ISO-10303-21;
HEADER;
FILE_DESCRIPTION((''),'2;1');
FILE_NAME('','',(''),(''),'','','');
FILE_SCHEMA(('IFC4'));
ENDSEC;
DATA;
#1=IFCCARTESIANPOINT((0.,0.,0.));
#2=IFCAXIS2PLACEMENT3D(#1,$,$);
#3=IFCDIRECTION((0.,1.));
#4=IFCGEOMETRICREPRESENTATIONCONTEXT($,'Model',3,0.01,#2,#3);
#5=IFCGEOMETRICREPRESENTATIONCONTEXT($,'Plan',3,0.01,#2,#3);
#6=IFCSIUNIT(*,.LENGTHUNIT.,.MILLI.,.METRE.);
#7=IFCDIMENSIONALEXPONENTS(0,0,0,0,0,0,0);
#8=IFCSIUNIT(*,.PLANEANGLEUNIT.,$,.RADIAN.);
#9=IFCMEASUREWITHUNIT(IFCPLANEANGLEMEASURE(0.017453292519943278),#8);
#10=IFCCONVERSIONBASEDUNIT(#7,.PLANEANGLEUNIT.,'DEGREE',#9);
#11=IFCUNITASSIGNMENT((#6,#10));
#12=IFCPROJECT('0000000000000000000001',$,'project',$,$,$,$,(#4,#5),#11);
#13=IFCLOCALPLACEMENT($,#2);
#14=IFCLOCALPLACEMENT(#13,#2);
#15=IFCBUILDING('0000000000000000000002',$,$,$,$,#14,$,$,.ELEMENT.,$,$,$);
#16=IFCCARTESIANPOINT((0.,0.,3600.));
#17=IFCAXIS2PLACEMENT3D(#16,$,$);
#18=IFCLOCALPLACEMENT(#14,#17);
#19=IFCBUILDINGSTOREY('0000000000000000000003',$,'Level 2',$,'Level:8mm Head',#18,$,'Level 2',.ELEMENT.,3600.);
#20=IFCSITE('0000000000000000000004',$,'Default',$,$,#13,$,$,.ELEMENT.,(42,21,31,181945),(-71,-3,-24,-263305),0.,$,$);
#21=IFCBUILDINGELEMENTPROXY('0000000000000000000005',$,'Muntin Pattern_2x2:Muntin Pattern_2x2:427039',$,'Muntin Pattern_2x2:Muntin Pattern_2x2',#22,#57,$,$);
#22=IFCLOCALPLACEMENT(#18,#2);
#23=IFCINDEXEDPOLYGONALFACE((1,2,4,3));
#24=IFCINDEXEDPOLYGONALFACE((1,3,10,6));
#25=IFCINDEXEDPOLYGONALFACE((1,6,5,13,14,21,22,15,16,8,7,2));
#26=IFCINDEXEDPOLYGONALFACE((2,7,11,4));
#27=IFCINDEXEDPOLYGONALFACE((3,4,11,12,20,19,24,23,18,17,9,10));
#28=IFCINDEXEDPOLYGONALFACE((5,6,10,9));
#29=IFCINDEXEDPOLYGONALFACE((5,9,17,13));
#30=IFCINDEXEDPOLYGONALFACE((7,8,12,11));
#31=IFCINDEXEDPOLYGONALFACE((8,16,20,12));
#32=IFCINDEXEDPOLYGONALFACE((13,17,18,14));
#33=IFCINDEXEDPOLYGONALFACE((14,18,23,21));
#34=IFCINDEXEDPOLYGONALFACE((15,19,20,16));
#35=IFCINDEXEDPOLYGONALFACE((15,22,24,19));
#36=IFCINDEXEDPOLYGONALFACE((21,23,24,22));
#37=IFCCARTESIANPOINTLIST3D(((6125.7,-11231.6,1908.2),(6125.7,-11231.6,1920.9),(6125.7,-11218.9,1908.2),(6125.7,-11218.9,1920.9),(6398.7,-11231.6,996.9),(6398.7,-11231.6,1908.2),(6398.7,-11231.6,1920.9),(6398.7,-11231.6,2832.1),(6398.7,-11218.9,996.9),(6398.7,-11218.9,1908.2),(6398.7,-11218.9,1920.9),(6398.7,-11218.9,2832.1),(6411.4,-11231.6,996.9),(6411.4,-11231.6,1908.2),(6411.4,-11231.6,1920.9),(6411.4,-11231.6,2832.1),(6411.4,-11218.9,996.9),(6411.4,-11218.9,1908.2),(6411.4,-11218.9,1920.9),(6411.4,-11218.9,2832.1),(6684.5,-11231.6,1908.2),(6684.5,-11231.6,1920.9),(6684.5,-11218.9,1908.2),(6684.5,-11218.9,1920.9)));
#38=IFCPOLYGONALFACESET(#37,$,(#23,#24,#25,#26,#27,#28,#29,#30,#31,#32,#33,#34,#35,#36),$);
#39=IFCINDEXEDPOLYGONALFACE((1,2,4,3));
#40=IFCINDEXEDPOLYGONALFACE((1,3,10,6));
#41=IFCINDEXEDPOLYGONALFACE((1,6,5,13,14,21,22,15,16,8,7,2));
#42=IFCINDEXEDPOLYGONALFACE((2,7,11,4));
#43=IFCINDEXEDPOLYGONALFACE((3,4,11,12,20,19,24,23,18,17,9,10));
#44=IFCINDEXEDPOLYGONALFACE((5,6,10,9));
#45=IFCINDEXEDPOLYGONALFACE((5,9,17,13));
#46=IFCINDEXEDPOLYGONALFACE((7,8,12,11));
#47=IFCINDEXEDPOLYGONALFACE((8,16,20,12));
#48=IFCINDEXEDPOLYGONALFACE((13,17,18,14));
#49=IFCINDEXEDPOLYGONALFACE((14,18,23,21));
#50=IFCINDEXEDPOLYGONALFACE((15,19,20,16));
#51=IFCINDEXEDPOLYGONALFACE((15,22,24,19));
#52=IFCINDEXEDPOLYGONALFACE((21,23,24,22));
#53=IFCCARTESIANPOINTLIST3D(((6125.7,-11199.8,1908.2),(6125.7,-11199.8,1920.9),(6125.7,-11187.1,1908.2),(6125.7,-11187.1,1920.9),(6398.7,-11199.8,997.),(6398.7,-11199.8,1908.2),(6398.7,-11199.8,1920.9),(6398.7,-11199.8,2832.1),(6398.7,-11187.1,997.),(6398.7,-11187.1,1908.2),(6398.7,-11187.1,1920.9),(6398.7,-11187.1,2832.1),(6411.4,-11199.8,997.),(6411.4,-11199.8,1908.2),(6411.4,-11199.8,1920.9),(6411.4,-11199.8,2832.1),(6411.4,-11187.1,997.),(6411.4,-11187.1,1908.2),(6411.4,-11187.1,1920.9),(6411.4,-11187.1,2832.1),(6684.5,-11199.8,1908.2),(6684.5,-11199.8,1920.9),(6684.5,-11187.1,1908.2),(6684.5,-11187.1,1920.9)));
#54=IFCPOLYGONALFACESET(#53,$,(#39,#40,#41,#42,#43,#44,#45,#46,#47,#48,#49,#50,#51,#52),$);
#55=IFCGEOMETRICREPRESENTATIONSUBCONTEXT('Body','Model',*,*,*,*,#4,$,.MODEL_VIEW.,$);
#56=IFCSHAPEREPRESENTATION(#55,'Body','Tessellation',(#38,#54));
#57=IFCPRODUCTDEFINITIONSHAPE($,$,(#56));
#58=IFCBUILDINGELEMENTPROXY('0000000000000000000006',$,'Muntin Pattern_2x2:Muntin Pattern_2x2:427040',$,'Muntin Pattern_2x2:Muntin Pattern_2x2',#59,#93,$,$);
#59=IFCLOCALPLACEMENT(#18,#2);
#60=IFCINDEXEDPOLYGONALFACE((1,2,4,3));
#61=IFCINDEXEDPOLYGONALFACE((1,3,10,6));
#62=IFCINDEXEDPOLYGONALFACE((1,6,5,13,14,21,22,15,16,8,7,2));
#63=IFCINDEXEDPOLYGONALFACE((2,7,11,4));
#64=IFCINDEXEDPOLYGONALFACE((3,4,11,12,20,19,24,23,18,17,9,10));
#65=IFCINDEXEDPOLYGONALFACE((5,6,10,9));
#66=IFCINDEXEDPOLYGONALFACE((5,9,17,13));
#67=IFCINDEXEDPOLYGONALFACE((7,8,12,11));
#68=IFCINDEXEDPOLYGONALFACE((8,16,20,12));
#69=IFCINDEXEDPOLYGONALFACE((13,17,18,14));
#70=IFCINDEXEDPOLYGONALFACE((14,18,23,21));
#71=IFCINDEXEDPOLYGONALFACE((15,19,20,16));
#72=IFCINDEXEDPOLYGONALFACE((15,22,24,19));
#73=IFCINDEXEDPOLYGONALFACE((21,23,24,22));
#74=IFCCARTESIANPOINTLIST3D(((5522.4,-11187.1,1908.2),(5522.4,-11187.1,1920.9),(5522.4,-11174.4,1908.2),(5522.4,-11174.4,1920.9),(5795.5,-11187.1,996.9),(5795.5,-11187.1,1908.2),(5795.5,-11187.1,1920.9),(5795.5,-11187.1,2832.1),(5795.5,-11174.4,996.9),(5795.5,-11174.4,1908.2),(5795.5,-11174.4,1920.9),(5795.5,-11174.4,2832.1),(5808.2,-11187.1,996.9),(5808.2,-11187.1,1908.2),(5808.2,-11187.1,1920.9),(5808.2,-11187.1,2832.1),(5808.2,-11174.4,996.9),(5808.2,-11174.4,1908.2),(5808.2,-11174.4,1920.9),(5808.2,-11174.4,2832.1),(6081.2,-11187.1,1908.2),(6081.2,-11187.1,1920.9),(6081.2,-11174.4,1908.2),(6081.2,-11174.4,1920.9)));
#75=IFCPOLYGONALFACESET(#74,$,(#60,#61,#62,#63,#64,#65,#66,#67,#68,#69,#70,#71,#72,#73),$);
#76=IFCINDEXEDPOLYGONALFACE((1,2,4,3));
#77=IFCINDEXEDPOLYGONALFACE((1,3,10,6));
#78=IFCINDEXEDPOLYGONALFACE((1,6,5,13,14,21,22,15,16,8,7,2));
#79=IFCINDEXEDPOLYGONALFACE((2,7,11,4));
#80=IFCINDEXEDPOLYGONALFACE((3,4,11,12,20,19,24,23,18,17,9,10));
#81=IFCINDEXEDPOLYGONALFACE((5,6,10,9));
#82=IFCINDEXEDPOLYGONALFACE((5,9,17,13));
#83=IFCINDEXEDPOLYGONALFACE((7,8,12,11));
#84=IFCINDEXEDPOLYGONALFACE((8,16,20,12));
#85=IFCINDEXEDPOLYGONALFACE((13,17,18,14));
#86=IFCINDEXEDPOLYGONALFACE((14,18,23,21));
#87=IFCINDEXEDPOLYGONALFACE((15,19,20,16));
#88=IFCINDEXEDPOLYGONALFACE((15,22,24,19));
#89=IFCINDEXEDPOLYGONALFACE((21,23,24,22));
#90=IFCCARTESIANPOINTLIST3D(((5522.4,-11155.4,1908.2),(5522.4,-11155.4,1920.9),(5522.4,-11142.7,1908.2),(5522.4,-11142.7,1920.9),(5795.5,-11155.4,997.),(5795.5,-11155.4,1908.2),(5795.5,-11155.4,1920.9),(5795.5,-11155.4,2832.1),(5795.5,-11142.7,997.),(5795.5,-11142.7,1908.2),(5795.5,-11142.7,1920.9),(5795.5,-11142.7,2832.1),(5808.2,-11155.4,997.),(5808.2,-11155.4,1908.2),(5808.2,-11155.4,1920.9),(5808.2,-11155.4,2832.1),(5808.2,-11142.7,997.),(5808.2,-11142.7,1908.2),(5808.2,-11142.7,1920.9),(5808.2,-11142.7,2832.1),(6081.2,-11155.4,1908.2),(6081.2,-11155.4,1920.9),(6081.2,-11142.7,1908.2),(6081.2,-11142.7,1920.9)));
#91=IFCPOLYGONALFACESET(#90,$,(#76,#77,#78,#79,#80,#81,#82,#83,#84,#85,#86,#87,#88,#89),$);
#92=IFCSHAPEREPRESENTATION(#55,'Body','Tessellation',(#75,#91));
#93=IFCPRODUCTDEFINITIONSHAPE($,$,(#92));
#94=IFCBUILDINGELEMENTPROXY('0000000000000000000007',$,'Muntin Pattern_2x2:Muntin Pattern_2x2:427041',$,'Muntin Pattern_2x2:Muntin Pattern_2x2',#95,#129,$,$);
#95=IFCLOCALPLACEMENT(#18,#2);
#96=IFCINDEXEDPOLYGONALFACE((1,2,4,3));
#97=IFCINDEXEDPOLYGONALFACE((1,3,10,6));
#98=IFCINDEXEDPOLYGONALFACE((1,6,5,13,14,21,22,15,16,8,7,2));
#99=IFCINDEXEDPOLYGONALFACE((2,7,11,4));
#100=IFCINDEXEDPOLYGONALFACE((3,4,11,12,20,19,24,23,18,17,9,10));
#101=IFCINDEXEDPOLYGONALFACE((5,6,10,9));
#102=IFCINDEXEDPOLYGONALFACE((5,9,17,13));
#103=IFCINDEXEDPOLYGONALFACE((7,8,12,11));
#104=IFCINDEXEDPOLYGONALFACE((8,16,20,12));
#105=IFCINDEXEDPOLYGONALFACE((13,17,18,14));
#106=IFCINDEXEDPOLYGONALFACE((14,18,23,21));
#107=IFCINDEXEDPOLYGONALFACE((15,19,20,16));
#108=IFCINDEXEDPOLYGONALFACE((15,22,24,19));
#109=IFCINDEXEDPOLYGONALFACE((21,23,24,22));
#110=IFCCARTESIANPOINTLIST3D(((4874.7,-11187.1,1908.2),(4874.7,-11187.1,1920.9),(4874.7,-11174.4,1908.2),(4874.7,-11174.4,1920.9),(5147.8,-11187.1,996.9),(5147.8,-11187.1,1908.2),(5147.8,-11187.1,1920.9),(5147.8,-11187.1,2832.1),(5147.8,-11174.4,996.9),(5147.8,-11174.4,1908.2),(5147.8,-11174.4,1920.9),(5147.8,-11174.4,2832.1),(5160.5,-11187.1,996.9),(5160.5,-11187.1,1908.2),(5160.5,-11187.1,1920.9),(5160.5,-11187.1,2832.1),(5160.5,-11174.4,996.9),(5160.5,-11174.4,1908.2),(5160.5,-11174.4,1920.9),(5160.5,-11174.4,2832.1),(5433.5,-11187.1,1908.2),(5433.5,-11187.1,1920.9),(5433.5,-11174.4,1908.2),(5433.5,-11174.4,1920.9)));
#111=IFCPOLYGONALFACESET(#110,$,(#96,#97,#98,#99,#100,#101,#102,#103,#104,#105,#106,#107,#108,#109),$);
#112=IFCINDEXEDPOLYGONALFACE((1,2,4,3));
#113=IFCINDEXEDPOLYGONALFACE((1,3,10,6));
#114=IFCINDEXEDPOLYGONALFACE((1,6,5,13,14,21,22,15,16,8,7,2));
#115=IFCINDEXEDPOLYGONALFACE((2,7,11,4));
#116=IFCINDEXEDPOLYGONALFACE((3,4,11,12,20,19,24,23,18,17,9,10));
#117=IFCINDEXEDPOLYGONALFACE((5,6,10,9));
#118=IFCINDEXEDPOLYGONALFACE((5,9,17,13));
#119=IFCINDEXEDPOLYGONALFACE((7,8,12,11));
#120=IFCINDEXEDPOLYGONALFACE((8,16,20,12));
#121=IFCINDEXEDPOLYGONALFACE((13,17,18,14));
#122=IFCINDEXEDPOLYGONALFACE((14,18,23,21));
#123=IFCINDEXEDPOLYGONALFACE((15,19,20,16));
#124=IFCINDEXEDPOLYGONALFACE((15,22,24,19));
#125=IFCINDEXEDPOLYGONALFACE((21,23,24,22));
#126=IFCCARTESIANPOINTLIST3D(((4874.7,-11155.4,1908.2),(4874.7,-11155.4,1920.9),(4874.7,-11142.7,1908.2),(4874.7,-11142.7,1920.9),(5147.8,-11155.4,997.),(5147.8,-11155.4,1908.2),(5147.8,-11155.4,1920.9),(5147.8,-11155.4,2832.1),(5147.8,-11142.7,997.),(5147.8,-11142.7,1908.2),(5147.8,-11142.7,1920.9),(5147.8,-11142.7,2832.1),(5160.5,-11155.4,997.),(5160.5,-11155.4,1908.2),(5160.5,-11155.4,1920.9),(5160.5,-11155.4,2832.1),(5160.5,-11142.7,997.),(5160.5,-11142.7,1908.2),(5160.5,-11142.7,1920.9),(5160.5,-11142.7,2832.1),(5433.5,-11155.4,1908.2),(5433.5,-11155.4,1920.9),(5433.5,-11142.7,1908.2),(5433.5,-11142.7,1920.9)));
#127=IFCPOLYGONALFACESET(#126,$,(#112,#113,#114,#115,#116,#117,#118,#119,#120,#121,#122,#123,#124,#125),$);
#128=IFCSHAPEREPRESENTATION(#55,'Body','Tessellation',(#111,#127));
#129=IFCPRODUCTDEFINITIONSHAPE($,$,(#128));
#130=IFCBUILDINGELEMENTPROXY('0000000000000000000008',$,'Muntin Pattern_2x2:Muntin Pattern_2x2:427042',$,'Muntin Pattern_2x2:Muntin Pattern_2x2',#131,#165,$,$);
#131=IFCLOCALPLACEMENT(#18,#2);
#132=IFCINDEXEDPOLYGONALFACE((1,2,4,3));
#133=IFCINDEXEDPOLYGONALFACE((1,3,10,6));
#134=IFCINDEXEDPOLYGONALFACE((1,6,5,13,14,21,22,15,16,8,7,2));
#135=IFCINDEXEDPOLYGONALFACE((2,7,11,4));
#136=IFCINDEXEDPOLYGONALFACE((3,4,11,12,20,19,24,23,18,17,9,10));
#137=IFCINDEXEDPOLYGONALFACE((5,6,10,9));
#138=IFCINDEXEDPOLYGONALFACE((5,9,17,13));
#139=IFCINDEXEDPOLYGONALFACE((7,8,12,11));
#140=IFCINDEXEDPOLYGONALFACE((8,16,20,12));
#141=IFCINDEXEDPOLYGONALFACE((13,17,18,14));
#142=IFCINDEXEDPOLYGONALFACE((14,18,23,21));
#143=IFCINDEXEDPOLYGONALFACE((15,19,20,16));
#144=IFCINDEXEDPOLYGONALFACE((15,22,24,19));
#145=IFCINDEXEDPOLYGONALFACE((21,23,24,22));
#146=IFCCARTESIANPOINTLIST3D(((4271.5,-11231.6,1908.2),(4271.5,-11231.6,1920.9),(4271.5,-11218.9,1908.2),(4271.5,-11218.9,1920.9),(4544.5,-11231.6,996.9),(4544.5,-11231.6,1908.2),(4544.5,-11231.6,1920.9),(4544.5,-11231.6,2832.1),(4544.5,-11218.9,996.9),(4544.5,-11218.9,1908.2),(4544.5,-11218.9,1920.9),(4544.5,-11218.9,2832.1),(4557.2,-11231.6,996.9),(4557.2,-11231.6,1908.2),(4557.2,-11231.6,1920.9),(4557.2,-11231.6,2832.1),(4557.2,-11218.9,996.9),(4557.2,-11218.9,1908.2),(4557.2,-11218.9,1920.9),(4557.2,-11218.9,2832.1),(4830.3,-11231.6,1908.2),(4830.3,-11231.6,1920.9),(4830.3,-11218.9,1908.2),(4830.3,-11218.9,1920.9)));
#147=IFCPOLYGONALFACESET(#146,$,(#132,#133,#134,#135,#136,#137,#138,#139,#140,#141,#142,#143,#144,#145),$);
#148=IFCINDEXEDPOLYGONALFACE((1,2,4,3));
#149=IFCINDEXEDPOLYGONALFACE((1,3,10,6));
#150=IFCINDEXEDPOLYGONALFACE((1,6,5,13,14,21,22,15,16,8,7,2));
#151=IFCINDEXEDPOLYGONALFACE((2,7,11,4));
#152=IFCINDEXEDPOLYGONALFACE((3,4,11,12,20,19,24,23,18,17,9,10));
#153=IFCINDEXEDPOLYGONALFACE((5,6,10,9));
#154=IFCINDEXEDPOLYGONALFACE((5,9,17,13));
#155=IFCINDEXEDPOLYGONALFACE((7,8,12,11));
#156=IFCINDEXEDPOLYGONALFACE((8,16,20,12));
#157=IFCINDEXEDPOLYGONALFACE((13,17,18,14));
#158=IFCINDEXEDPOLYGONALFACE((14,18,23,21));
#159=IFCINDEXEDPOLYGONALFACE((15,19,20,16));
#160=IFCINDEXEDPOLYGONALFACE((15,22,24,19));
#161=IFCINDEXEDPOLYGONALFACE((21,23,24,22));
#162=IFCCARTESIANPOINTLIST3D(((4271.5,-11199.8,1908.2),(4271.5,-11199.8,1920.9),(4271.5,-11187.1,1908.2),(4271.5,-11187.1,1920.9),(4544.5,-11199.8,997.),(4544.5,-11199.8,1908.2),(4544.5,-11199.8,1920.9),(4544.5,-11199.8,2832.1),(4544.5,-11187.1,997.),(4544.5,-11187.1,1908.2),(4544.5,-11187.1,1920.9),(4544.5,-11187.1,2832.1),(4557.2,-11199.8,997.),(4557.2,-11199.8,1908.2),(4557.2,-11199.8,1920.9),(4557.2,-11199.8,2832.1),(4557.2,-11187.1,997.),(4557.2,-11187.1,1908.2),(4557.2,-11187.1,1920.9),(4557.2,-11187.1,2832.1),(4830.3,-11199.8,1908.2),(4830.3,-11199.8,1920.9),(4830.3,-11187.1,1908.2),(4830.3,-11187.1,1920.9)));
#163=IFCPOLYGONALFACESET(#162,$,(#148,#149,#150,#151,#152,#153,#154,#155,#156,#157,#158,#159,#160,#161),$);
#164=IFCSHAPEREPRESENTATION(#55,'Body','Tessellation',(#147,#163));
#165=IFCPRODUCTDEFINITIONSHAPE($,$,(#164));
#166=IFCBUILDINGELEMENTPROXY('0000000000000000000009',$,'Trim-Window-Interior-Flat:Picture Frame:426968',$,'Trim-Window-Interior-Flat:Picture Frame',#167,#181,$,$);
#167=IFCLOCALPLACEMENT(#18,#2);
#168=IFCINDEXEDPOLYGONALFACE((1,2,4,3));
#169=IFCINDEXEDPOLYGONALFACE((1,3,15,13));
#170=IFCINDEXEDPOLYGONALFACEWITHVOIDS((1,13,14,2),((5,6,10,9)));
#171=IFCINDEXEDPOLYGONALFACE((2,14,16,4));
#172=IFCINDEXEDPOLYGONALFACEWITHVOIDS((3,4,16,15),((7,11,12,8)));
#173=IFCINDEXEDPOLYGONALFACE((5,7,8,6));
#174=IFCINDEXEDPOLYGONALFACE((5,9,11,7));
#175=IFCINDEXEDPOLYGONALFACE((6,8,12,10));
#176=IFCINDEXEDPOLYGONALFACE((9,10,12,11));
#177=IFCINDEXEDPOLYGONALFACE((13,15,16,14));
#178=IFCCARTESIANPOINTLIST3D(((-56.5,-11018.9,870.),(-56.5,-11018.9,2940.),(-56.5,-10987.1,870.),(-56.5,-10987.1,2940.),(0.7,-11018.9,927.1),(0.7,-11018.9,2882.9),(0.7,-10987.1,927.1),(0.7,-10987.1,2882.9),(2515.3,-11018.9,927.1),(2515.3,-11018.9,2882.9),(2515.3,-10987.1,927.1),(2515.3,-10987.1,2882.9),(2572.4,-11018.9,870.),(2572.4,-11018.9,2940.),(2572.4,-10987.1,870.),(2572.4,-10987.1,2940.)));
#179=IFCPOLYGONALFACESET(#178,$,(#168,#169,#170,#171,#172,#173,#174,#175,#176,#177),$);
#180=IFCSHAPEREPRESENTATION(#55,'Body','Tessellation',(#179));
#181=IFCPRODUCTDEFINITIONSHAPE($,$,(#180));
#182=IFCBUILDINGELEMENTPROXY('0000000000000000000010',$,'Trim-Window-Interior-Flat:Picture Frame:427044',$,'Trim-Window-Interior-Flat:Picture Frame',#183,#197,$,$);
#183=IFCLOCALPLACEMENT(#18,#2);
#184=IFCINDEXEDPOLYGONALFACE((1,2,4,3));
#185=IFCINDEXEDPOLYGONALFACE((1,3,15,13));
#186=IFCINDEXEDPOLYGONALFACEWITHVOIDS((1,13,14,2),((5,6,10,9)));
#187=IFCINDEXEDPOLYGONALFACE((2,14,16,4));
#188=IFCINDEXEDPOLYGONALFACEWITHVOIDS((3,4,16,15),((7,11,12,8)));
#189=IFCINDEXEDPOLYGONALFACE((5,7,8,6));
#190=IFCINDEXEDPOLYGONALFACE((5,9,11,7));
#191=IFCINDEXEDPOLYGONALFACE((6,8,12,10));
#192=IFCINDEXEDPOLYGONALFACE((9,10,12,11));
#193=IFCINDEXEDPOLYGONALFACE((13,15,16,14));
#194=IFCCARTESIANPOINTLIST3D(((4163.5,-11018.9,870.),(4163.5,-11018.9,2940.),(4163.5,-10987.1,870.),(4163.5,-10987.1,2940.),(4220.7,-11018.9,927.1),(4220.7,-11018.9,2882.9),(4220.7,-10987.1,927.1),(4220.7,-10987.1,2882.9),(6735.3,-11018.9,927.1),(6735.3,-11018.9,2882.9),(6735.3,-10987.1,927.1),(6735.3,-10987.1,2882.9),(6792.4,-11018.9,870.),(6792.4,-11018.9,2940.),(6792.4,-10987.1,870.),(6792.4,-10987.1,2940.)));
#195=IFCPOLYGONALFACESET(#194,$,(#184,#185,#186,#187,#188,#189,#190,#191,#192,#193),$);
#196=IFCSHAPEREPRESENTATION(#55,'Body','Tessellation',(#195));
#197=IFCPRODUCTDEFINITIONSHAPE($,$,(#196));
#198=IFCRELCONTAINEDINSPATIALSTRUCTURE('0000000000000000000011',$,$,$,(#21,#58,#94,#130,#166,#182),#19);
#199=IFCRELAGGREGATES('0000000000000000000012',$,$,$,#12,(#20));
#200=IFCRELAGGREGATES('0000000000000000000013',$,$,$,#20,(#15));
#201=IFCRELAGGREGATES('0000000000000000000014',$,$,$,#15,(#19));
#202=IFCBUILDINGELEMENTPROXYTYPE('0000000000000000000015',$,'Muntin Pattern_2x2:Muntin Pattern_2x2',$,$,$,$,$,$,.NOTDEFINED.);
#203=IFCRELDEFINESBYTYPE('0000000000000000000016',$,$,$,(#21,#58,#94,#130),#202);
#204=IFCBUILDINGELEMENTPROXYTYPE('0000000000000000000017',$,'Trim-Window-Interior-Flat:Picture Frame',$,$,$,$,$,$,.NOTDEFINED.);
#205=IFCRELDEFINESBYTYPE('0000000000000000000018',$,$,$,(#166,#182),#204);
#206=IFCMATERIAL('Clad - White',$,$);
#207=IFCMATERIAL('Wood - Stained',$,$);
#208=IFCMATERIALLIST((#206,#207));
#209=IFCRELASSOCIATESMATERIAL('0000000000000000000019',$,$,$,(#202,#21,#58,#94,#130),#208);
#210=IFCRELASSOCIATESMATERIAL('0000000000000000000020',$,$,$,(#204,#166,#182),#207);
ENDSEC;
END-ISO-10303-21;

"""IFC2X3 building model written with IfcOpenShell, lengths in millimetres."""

from ifc_helpers import new_model, entity, si_unit, converted_unit, direction, frame, origin, place, context, subcontext, project, spatial, polyline, outline, extrude, source, transform, mapped, material, material_list, type_object, type_shapes, element, save


model = new_model("IFC2X3")

# Units and contexts
model_context = context("Model", 3, precision=0.01, world=origin(), true_north=direction((0.0, 1.0)))
plan_context = context("Plan", 3, precision=0.01, world=origin(), true_north=direction((0.0, 1.0)))
body_context = subcontext(model_context, "Body", "Model", "MODEL_VIEW")
ifc_project = project(units=[si_unit("LENGTHUNIT", "METRE", prefix="MILLI"), converted_unit("PLANEANGLEUNIT", "DEGREE", entity("IfcPlaneAngleMeasure", 0.017453292519943278), si_unit("PLANEANGLEUNIT", "RADIAN"), dimensions=[0, 0, 0, 0, 0, 0, 0])], contexts=[model_context, plan_context])

# Site, building, storey
site_placement = place(None, origin())
site = spatial("IfcSite", under=ifc_project, at=site_placement, Name="Default", CompositionType="ELEMENT", RefLatitude=(42, 21, 31, 181945), RefLongitude=(-71, -3, -24, -263305), RefElevation=0.0)
building_placement = place(site_placement, origin())
building = spatial("IfcBuilding", under=site, at=building_placement, CompositionType="ELEMENT")
storey_placement = place(building_placement, frame((0.0, 0.0, 3600.0)))
storey = spatial("IfcBuildingStorey", under=building, at=storey_placement, Name="Level 2", ObjectType="Level:8mm Head", LongName="Level 2", CompositionType="ELEMENT", Elevation=3600.0)

# Building element proxies
ifc_material_1 = material(Name="Clad - White")
ifc_material_2 = material(Name="Wood - Stained")
ifc_material_list = material_list([ifc_material_1, ifc_material_2])
building_element_proxy_type_1 = type_object("IfcBuildingElementProxyType", Name="Muntin Pattern_2x2:Muntin Pattern_2x2", PredefinedType="NOTDEFINED", material=ifc_material_list)
shared_shape_1 = source(origin(), body_context, "Body", "SweptSolid", [
    extrude(outline(polyline([(6.4, -6.4), (917.6, -6.4), (917.6, 6.3), (6.4, 6.3), (6.4, 279.4), (-6.3, 279.4), (-6.3, 6.3), (-917.6, 6.3), (-917.6, -6.4), (-6.3, -6.4), (-6.3, -279.4), (6.4, -279.4), (6.4, -6.4)])), frame((0.0, 9.5, 917.6), z_axis=(0.0, 1.0, 0.0), x_axis=(0.0, 0.0, 1.0)), (0.0, 0.0, 1.0), 12.7),
    extrude(outline(polyline([(6.4, -6.4), (917.6, -6.4), (917.6, 6.3), (6.4, 6.3), (6.4, 279.4), (-6.3, 279.4), (-6.3, 6.3), (-917.6, 6.3), (-917.6, -6.4), (-6.3, -6.4), (-6.3, -279.4), (6.4, -279.4), (6.4, -6.4)])), frame((0.0, -22.2, 917.6), z_axis=(0.0, 1.0, 0.0), x_axis=(0.0, 0.0, 1.0)), (0.0, 0.0, 1.0), 12.7),
])
type_shapes(building_element_proxy_type_1, [shared_shape_1])
for number, where, z_axis, x_axis, name in (
    (1, (6405.1, -11209.4, 997.0), (0.0, 0.0, 1.0), (-1.0, 0.0, 0.0), "Muntin Pattern_2x2:Muntin Pattern_2x2:427039"),
    (2, (5801.8, -11164.9, 997.0), (0.0, 0.0, 1.0), (-1.0, 0.0, 0.0), "Muntin Pattern_2x2:Muntin Pattern_2x2:427040"),
    (3, (5154.1, -11164.9, 997.0), (0.0, 0.0, 1.0), (-1.0, 0.0, 0.0), "Muntin Pattern_2x2:Muntin Pattern_2x2:427041"),
    (4, (4550.9, -11209.4, 997.0), (0.0, 0.0, 1.0), (-1.0, 0.0, 0.0), "Muntin Pattern_2x2:Muntin Pattern_2x2:427042"),
):
    element("IfcBuildingElementProxy", number, at=place(storey_placement, frame(where, z_axis=z_axis, x_axis=x_axis)), inside=storey, type_object=building_element_proxy_type_1, material=ifc_material_list, Name=name, ObjectType="Muntin Pattern_2x2:Muntin Pattern_2x2", context=body_context, shape_type="MappedRepresentation", body=[
        mapped(shared_shape_1, transform((0.0, 0.0, 0.0), scale=1.0)),
    ])
building_element_proxy_type_2 = type_object("IfcBuildingElementProxyType", Name="Trim-Window-Interior-Flat:Picture Frame", PredefinedType="NOTDEFINED", material=ifc_material_2)
shared_shape_2 = source(origin(), body_context, "Body", "SweptSolid", [
    extrude(outline(polyline([(-1314.4, -1035.0), (1314.4, -1035.0), (1314.4, 1035.0), (-1314.4, 1035.0), (-1314.4, -1035.0)]), holes=[polyline([(-1257.3, -977.9), (-1257.3, 977.9), (1257.3, 977.9), (1257.3, -977.9), (-1257.3, -977.9)])]), frame((0.0, -990.6, 0.0), z_axis=(0.0, 0.0, 1.0), x_axis=(-1.0, 0.0, 0.0)), (0.0, 0.0, 1.0), 31.7),
])
type_shapes(building_element_proxy_type_2, [shared_shape_2])
for number, where, z_axis, x_axis, name in (
    (5, (1258.0, -11018.9, 2895.6), (0.0, 1.0, 0.0), (-1.0, 0.0, 0.0), "Trim-Window-Interior-Flat:Picture Frame:426968"),
    (6, (5478.0, -11018.9, 2895.6), (0.0, 1.0, 0.0), (-1.0, 0.0, 0.0), "Trim-Window-Interior-Flat:Picture Frame:427044"),
):
    element("IfcBuildingElementProxy", number, at=place(storey_placement, frame(where, z_axis=z_axis, x_axis=x_axis)), inside=storey, type_object=building_element_proxy_type_2, material=ifc_material_2, Name=name, ObjectType="Trim-Window-Interior-Flat:Picture Frame", context=body_context, shape_type="MappedRepresentation", body=[
        mapped(shared_shape_2, transform((0.0, 0.0, 0.0), scale=1.0)),
    ])

save(model, "model.ifc")
